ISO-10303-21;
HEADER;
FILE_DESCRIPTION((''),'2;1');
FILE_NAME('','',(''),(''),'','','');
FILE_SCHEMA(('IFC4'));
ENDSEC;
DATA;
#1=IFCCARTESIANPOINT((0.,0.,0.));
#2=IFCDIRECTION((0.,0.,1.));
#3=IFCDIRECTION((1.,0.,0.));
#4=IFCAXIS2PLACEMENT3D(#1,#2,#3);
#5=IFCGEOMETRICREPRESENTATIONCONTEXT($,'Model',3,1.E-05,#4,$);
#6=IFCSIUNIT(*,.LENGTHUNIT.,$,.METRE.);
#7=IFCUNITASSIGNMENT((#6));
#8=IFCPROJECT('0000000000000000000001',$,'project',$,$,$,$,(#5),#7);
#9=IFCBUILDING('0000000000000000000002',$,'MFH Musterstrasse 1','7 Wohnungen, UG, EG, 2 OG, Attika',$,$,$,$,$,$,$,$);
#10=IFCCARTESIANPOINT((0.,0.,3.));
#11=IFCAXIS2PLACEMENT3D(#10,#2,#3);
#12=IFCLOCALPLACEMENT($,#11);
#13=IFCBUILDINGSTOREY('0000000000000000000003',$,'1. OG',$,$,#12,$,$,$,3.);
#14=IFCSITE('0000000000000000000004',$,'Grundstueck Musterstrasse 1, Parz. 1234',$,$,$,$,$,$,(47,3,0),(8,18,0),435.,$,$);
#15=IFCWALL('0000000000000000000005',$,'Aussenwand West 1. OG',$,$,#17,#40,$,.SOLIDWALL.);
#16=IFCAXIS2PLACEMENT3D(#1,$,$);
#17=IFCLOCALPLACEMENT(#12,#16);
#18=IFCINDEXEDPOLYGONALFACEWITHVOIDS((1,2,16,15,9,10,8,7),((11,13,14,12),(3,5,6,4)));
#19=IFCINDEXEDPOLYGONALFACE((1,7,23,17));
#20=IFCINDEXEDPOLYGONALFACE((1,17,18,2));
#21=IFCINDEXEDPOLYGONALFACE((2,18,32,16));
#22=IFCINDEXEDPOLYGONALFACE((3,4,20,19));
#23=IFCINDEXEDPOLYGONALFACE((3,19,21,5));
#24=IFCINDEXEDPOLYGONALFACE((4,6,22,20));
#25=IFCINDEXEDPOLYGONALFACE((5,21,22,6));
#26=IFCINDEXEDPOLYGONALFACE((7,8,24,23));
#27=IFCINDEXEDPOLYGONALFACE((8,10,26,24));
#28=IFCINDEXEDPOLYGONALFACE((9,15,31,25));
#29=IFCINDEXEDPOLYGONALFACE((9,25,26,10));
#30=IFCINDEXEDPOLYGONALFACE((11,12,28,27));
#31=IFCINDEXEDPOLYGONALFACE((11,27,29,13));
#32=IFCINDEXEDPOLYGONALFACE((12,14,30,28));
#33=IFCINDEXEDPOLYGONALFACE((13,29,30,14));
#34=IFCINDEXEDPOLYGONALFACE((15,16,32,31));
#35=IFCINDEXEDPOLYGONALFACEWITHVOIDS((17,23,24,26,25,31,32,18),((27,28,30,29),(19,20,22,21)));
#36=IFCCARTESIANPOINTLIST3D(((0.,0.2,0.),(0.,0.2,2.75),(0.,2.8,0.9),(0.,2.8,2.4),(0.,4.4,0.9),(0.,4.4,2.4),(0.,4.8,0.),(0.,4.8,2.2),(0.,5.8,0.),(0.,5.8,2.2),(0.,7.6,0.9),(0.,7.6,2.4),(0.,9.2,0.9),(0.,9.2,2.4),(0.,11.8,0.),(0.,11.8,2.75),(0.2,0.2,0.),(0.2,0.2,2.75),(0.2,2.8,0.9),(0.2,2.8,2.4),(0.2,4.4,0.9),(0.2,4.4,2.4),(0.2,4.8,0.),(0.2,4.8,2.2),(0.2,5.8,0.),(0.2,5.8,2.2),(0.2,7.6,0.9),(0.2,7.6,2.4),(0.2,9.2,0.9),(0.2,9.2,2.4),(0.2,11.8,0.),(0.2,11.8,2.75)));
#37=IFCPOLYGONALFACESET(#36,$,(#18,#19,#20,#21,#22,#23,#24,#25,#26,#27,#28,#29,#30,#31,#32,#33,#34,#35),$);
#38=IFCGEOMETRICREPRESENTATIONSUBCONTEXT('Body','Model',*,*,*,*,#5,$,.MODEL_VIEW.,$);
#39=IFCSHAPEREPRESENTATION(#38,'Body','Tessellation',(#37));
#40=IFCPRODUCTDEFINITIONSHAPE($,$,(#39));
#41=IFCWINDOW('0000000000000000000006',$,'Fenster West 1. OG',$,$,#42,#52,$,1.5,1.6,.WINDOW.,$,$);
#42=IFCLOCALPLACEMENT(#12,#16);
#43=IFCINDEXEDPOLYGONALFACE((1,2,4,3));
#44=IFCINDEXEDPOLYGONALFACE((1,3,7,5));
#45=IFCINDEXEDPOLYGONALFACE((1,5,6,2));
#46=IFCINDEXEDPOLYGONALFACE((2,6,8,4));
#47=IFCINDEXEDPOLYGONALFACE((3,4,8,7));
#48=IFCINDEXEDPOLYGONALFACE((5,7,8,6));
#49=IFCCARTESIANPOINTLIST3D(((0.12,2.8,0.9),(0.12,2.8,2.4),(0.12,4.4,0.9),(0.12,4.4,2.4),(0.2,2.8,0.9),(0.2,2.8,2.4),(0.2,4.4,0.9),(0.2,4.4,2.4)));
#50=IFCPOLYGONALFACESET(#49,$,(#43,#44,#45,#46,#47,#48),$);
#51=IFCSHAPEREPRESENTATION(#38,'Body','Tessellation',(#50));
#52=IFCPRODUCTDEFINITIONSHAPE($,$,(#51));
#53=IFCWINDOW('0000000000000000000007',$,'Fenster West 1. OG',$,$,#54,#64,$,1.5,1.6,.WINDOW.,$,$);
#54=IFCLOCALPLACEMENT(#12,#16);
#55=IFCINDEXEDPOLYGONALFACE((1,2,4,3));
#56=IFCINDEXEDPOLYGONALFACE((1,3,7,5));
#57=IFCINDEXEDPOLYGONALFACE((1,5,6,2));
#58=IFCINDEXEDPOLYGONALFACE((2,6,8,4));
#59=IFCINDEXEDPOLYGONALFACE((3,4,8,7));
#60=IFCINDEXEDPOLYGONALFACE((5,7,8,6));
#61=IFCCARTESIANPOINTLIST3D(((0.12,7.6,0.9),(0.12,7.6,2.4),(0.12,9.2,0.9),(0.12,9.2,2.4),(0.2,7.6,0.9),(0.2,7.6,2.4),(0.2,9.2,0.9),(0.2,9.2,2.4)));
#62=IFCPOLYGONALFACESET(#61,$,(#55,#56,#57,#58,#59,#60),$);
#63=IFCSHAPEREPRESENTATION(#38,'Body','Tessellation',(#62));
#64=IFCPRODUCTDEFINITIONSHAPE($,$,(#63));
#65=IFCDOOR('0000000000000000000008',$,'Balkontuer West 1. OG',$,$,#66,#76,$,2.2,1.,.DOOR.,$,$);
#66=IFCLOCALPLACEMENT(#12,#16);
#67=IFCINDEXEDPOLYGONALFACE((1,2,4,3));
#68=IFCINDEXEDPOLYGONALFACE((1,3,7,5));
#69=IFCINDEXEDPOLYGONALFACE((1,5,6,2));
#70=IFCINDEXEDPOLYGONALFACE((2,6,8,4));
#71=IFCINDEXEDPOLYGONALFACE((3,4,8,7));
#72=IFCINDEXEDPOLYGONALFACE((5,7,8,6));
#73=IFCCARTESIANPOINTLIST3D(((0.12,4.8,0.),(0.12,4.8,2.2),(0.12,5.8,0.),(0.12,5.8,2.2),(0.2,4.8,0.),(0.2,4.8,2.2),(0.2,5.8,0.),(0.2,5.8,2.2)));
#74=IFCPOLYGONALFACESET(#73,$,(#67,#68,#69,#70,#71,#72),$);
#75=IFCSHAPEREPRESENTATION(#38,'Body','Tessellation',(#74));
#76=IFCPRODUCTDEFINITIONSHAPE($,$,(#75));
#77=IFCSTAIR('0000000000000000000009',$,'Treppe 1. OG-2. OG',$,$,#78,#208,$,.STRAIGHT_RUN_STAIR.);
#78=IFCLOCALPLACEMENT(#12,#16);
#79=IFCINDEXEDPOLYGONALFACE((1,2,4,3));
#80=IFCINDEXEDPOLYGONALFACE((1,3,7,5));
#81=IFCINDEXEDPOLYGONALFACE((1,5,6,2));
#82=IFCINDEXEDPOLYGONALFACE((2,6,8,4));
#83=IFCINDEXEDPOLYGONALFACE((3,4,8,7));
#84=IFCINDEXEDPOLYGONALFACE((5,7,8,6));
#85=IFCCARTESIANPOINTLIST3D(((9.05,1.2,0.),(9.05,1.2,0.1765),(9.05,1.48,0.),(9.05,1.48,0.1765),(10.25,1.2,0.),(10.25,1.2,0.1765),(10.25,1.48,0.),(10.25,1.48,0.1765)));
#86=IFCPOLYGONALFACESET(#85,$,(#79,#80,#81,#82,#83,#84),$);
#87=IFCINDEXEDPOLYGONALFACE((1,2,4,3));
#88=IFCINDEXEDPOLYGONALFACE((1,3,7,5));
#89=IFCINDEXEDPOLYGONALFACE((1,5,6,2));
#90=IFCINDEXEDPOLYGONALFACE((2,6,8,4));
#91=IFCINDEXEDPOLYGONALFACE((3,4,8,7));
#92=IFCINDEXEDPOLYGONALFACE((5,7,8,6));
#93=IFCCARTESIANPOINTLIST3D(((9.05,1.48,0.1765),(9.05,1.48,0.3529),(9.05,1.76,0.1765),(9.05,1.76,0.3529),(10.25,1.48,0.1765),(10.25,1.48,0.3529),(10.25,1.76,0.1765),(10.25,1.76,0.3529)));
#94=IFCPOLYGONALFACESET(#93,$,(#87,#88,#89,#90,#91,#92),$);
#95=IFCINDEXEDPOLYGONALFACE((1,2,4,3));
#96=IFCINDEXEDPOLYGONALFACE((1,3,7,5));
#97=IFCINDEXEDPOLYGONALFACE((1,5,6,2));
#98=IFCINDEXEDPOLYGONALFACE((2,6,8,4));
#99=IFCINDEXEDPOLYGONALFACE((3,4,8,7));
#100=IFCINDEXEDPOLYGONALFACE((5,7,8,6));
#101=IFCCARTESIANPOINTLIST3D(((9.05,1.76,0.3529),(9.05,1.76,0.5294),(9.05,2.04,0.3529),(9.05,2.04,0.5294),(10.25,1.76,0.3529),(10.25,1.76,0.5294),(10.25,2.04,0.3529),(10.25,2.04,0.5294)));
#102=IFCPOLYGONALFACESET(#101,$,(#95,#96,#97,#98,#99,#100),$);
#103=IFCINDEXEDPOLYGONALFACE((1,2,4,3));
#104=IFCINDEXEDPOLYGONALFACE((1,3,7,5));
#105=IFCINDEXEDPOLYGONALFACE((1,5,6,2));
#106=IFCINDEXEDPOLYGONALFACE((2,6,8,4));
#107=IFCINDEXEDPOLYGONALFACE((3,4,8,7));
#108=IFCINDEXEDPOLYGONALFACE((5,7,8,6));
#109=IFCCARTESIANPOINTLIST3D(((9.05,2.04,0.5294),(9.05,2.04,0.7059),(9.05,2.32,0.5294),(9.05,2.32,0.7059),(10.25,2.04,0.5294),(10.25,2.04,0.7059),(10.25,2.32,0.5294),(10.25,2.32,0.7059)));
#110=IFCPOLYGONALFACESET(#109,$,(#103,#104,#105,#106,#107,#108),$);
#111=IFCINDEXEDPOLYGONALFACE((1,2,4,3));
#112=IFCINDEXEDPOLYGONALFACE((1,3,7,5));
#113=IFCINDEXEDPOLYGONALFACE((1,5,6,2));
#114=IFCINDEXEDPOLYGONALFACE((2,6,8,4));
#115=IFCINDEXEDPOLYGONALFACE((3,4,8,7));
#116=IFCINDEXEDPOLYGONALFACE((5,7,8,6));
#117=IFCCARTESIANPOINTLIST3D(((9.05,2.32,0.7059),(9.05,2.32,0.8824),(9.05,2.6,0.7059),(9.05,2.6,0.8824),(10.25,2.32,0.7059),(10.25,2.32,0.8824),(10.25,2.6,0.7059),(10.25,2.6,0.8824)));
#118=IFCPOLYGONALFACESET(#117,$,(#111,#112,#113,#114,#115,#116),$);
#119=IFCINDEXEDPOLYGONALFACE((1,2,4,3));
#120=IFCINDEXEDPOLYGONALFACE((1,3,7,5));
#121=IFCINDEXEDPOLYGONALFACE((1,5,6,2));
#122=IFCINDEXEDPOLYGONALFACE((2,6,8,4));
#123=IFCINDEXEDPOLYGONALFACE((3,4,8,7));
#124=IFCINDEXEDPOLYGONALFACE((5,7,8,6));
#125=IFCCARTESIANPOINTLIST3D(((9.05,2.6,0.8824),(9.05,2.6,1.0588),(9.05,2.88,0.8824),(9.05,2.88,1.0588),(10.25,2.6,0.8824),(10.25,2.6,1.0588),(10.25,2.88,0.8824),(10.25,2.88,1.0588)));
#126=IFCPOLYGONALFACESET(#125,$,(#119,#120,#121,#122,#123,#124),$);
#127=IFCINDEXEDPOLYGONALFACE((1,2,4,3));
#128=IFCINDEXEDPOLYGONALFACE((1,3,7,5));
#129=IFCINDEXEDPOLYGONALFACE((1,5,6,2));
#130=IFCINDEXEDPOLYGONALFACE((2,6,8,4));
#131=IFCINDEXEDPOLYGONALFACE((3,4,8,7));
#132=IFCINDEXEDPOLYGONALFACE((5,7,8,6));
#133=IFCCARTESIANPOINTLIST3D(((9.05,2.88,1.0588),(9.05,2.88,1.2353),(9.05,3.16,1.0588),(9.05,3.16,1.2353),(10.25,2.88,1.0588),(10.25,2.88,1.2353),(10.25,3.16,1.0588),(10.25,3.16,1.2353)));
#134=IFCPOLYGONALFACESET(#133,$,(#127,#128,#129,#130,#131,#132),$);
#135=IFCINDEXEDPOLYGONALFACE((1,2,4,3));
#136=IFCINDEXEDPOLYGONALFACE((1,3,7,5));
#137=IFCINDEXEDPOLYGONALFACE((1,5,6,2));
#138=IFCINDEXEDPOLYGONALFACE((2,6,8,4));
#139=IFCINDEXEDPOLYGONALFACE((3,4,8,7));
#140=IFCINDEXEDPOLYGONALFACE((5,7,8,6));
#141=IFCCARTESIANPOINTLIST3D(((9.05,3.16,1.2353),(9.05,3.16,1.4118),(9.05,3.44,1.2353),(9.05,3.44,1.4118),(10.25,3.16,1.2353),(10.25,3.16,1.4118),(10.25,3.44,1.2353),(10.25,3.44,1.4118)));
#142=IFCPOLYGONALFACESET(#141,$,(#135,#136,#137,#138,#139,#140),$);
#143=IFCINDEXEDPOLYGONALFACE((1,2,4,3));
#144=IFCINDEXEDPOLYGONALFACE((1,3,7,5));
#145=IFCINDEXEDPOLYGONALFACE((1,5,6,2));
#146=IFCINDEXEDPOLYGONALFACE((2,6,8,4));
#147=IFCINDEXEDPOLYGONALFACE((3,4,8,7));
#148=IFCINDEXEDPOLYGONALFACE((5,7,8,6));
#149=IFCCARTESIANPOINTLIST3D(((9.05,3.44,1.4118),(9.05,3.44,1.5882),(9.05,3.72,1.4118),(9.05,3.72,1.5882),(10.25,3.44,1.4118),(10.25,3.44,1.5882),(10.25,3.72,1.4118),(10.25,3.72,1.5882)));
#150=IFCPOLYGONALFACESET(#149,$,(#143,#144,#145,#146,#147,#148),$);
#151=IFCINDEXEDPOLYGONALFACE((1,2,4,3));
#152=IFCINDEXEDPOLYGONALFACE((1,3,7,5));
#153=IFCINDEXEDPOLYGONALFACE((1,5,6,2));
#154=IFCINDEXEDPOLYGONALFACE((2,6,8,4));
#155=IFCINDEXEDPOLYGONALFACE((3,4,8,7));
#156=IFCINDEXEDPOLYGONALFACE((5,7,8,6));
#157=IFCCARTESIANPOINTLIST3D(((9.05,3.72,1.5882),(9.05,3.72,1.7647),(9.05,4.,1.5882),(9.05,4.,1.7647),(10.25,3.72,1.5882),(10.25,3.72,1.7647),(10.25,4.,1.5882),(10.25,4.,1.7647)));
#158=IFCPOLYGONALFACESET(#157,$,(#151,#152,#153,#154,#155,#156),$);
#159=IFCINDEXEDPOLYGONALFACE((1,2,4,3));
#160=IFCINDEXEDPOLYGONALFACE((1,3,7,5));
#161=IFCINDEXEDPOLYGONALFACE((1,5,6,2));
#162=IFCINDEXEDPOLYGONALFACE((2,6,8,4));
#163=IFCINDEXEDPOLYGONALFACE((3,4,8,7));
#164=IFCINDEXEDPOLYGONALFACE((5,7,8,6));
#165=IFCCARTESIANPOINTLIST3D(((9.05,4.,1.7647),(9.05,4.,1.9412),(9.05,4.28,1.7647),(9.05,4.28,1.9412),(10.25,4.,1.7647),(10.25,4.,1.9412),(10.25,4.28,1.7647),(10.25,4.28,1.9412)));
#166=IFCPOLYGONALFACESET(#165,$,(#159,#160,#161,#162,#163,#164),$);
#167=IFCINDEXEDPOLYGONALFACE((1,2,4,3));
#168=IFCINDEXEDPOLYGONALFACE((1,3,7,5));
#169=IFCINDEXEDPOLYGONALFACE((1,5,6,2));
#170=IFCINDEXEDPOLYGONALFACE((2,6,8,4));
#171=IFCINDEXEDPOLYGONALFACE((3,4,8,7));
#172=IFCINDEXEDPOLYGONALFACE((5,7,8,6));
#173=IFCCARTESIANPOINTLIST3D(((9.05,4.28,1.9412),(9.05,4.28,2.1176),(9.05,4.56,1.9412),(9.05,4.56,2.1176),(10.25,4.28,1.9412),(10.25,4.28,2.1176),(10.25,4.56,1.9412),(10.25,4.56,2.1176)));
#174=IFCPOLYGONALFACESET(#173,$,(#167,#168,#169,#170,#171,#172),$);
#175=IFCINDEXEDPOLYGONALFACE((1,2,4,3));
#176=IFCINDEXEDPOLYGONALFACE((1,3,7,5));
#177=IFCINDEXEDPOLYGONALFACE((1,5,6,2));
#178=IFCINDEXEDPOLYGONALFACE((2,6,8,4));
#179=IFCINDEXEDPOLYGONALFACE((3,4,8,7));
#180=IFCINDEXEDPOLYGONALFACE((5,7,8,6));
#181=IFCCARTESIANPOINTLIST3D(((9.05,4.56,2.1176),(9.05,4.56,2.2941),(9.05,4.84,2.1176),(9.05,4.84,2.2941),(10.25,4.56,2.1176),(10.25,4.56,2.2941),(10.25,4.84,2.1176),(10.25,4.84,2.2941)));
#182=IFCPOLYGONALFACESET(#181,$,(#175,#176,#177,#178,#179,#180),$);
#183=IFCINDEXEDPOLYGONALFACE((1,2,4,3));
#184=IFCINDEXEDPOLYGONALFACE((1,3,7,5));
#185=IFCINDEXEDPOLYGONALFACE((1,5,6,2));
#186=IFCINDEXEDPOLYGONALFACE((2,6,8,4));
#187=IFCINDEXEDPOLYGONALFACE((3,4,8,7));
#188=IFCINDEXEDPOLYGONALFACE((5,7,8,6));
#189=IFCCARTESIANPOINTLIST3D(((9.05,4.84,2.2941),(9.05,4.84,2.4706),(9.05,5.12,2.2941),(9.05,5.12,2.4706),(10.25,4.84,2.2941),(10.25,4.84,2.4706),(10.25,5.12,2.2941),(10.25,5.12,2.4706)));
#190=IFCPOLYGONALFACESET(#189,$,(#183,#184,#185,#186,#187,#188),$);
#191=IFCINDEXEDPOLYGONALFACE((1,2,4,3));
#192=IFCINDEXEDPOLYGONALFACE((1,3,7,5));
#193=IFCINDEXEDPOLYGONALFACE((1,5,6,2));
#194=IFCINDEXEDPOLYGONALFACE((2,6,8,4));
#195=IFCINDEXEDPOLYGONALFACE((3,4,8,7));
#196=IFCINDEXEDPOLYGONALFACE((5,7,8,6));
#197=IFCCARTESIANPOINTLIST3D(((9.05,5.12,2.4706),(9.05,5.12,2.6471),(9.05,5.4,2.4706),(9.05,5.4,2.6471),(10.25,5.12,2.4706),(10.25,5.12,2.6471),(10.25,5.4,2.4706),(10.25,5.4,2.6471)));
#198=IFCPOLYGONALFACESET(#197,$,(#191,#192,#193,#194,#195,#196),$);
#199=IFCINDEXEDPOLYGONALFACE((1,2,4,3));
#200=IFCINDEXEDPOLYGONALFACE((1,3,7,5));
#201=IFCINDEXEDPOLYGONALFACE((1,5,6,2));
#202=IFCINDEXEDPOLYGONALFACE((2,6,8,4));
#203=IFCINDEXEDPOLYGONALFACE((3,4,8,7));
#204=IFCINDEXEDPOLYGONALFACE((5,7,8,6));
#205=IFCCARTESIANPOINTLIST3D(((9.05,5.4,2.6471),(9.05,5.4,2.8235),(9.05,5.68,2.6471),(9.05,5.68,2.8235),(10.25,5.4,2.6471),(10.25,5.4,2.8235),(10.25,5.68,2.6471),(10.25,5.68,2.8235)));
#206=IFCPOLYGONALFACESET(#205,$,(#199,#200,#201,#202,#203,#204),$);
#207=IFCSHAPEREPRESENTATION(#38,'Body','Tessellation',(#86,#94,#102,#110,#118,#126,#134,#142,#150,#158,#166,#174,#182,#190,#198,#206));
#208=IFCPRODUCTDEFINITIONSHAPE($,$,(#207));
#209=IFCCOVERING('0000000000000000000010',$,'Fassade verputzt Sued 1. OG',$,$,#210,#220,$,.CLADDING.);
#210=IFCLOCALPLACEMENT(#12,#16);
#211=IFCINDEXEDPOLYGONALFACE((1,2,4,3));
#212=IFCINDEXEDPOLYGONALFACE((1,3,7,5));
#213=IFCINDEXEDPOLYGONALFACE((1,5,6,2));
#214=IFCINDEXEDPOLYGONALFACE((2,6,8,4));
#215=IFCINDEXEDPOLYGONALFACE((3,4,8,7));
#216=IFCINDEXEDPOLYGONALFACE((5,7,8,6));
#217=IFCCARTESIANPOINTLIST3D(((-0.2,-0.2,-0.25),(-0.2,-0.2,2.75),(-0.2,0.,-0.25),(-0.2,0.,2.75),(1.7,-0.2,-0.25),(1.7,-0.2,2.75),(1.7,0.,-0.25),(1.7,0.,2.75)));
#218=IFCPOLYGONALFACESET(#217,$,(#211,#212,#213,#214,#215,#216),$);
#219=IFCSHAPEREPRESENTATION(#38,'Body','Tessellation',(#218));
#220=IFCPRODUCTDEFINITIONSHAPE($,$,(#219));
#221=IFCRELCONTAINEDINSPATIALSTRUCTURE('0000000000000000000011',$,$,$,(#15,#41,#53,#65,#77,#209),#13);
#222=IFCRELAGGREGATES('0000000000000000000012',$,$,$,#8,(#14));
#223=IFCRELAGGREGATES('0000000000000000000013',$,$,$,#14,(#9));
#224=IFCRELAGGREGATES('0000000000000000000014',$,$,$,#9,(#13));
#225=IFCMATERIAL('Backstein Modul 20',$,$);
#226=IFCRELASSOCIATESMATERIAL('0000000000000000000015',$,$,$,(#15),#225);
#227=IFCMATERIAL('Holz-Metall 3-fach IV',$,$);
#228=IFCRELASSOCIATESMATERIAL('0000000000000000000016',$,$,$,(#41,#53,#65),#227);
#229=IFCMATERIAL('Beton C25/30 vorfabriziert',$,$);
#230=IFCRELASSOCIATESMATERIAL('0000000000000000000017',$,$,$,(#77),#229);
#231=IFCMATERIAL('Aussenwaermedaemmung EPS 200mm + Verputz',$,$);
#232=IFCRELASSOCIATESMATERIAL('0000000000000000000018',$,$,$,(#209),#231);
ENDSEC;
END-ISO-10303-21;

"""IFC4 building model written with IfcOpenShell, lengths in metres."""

from ifc_helpers import new_model, si_unit, frame, frame_2d, origin_with_axes, place, context, subcontext, project, spatial, rectangle, extrude, material, element, fill, save


model = new_model("IFC4")

# Units and contexts
model_context = context("Model", 3, precision=1e-05, world=origin_with_axes())
body_context = subcontext(model_context, "Body", "Model", "MODEL_VIEW")
ifc_project = project(units=[si_unit("LENGTHUNIT", "METRE")], contexts=[model_context])

# Site, building, storey
site = spatial("IfcSite", under=ifc_project, Name="Grundstueck Musterstrasse 1, Parz. 1234", RefLatitude=(47, 3, 0), RefLongitude=(8, 18, 0), RefElevation=435.0)
building = spatial("IfcBuilding", under=site, Name="MFH Musterstrasse 1", Description="7 Wohnungen, UG, EG, 2 OG, Attika")
storey_placement = place(None, frame((0.0, 0.0, 3.0), z_axis=(0.0, 0.0, 1.0), x_axis=(1.0, 0.0, 0.0)))
storey = spatial("IfcBuildingStorey", under=building, at=storey_placement, Name="1. OG", Elevation=3.0)

# Shared definitions
ifc_material_1 = material(Name="Backstein Modul 20")

# Shared definitions
ifc_material_2 = material(Name="Holz-Metall 3-fach IV")

# Wall, openings, windows, door
wall_1_placement = place(storey_placement, frame((0.0, 0.2, 0.0), z_axis=(0.0, 0.0, 1.0), x_axis=(1.0, 0.0, 0.0)))
wall_1 = element("IfcWall", 1, at=wall_1_placement, inside=storey, material=ifc_material_1, Name="Aussenwand West 1. OG", PredefinedType="SOLIDWALL", context=body_context, shape_type="SweptSolid", body=[
    extrude(rectangle(XDim=0.2, YDim=11.6, at=frame_2d((0.1, 5.8))), origin_with_axes(), (0.0, 0.0, 1.0), 2.75),
])
opening_1_placement = place(wall_1_placement, frame((-0.21, 2.6, 0.9), z_axis=(0.0, 0.0, 1.0), x_axis=(1.0, 0.0, 0.0)))
opening_1 = element("IfcOpeningElement", 2, at=opening_1_placement, cuts=wall_1, context=body_context, shape_type="SweptSolid", body=[
    extrude(rectangle(XDim=0.42, YDim=1.6, at=frame_2d((0.21, 0.8))), origin_with_axes(), (0.0, 0.0, 1.0), 1.5),
])
opening_2_placement = place(wall_1_placement, frame((-0.21, 7.4, 0.9), z_axis=(0.0, 0.0, 1.0), x_axis=(1.0, 0.0, 0.0)))
opening_2 = element("IfcOpeningElement", 3, at=opening_2_placement, cuts=wall_1, context=body_context, shape_type="SweptSolid", body=[
    extrude(rectangle(XDim=0.42, YDim=1.6, at=frame_2d((0.21, 0.8))), origin_with_axes(), (0.0, 0.0, 1.0), 1.5),
])
opening_3_placement = place(wall_1_placement, frame((-0.21, 4.6, 0.0), z_axis=(0.0, 0.0, 1.0), x_axis=(1.0, 0.0, 0.0)))
opening_3 = element("IfcOpeningElement", 4, at=opening_3_placement, cuts=wall_1, context=body_context, shape_type="SweptSolid", body=[
    extrude(rectangle(XDim=0.42, YDim=1.0, at=frame_2d((0.21, 0.5))), origin_with_axes(), (0.0, 0.0, 1.0), 2.2),
])
window_1_placement = place(storey_placement, frame((0.12, 2.8, 0.9), z_axis=(0.0, 0.0, 1.0), x_axis=(1.0, 0.0, 0.0)))
window_1 = element("IfcWindow", 5, at=window_1_placement, inside=storey, material=ifc_material_2, Name="Fenster West 1. OG", OverallHeight=1.5, OverallWidth=1.6, PredefinedType="WINDOW", context=body_context, shape_type="SweptSolid", body=[
    extrude(rectangle(XDim=0.08, YDim=1.6, at=frame_2d((0.04, 0.8))), origin_with_axes(), (0.0, 0.0, 1.0), 1.5),
])
fill(opening_1, window_1)
window_2_placement = place(storey_placement, frame((0.12, 7.6, 0.9), z_axis=(0.0, 0.0, 1.0), x_axis=(1.0, 0.0, 0.0)))
window_2 = element("IfcWindow", 6, at=window_2_placement, inside=storey, material=ifc_material_2, Name="Fenster West 1. OG", OverallHeight=1.5, OverallWidth=1.6, PredefinedType="WINDOW", context=body_context, shape_type="SweptSolid", body=[
    extrude(rectangle(XDim=0.08, YDim=1.6, at=frame_2d((0.04, 0.8))), origin_with_axes(), (0.0, 0.0, 1.0), 1.5),
])
fill(opening_2, window_2)
door_1_placement = place(storey_placement, frame((0.12, 4.8, 0.0), z_axis=(0.0, 0.0, 1.0), x_axis=(1.0, 0.0, 0.0)))
door_1 = element("IfcDoor", 7, at=door_1_placement, inside=storey, material=ifc_material_2, Name="Balkontuer West 1. OG", OverallHeight=2.2, OverallWidth=1.0, PredefinedType="DOOR", context=body_context, shape_type="SweptSolid", body=[
    extrude(rectangle(XDim=0.08, YDim=1.0, at=frame_2d((0.04, 0.5))), origin_with_axes(), (0.0, 0.0, 1.0), 2.2),
])
fill(opening_3, door_1)

# Stair
ifc_material_3 = material(Name="Beton C25/30 vorfabriziert")
stair_placement = place(storey_placement, origin_with_axes())
element("IfcStair", 8, at=stair_placement, inside=storey, material=ifc_material_3, Name="Treppe 1. OG-2. OG", PredefinedType="STRAIGHT_RUN_STAIR", context=body_context, shape_type="SweptSolid", body=[
    extrude(rectangle(XDim=1.2, YDim=0.28, at=frame_2d((0.6, 0.14))), frame((9.05, 1.2, 0.0)), (0.0, 0.0, 1.0), 0.1765),
    extrude(rectangle(XDim=1.2, YDim=0.28, at=frame_2d((0.6, 0.14))), frame((9.05, 1.48, 0.1765)), (0.0, 0.0, 1.0), 0.1765),
    extrude(rectangle(XDim=1.2, YDim=0.28, at=frame_2d((0.6, 0.14))), frame((9.05, 1.76, 0.3529)), (0.0, 0.0, 1.0), 0.1765),
    extrude(rectangle(XDim=1.2, YDim=0.28, at=frame_2d((0.6, 0.14))), frame((9.05, 2.04, 0.5294)), (0.0, 0.0, 1.0), 0.1765),
    extrude(rectangle(XDim=1.2, YDim=0.28, at=frame_2d((0.6, 0.14))), frame((9.05, 2.32, 0.7059)), (0.0, 0.0, 1.0), 0.1765),
    extrude(rectangle(XDim=1.2, YDim=0.28, at=frame_2d((0.6, 0.14))), frame((9.05, 2.6, 0.8824)), (0.0, 0.0, 1.0), 0.1765),
    extrude(rectangle(XDim=1.2, YDim=0.28, at=frame_2d((0.6, 0.14))), frame((9.05, 2.88, 1.0588)), (0.0, 0.0, 1.0), 0.1765),
    extrude(rectangle(XDim=1.2, YDim=0.28, at=frame_2d((0.6, 0.14))), frame((9.05, 3.16, 1.2353)), (0.0, 0.0, 1.0), 0.1765),
    extrude(rectangle(XDim=1.2, YDim=0.28, at=frame_2d((0.6, 0.14))), frame((9.05, 3.44, 1.4118)), (0.0, 0.0, 1.0), 0.1765),
    extrude(rectangle(XDim=1.2, YDim=0.28, at=frame_2d((0.6, 0.14))), frame((9.05, 3.72, 1.5882)), (0.0, 0.0, 1.0), 0.1765),
    extrude(rectangle(XDim=1.2, YDim=0.28, at=frame_2d((0.6, 0.14))), frame((9.05, 4.0, 1.7647)), (0.0, 0.0, 1.0), 0.1765),
    extrude(rectangle(XDim=1.2, YDim=0.28, at=frame_2d((0.6, 0.14))), frame((9.05, 4.28, 1.9412)), (0.0, 0.0, 1.0), 0.1765),
    extrude(rectangle(XDim=1.2, YDim=0.28, at=frame_2d((0.6, 0.14))), frame((9.05, 4.56, 2.1176)), (0.0, 0.0, 1.0), 0.1765),
    extrude(rectangle(XDim=1.2, YDim=0.28, at=frame_2d((0.6, 0.14))), frame((9.05, 4.84, 2.2941)), (0.0, 0.0, 1.0), 0.1765),
    extrude(rectangle(XDim=1.2, YDim=0.28, at=frame_2d((0.6, 0.14))), frame((9.05, 5.12, 2.4706)), (0.0, 0.0, 1.0), 0.1765),
    extrude(rectangle(XDim=1.2, YDim=0.28, at=frame_2d((0.6, 0.14))), frame((9.05, 5.4, 2.6471)), (0.0, 0.0, 1.0), 0.1765),
])

# Shared definitions
ifc_material_4 = material(Name="Aussenwaermedaemmung EPS 200mm + Verputz")

# Covering
covering_1_placement = place(storey_placement, frame((-0.2, -0.2, -0.25), z_axis=(0.0, 0.0, 1.0), x_axis=(1.0, 0.0, 0.0)))
element("IfcCovering", 9, at=covering_1_placement, inside=storey, material=ifc_material_4, Name="Fassade verputzt Sued 1. OG", PredefinedType="CLADDING", context=body_context, shape_type="SweptSolid", body=[
    extrude(rectangle(XDim=1.9, YDim=0.2, at=frame_2d((0.95, 0.1))), origin_with_axes(), (0.0, 0.0, 1.0), 3.0),
])

save(model, "model.ifc")
